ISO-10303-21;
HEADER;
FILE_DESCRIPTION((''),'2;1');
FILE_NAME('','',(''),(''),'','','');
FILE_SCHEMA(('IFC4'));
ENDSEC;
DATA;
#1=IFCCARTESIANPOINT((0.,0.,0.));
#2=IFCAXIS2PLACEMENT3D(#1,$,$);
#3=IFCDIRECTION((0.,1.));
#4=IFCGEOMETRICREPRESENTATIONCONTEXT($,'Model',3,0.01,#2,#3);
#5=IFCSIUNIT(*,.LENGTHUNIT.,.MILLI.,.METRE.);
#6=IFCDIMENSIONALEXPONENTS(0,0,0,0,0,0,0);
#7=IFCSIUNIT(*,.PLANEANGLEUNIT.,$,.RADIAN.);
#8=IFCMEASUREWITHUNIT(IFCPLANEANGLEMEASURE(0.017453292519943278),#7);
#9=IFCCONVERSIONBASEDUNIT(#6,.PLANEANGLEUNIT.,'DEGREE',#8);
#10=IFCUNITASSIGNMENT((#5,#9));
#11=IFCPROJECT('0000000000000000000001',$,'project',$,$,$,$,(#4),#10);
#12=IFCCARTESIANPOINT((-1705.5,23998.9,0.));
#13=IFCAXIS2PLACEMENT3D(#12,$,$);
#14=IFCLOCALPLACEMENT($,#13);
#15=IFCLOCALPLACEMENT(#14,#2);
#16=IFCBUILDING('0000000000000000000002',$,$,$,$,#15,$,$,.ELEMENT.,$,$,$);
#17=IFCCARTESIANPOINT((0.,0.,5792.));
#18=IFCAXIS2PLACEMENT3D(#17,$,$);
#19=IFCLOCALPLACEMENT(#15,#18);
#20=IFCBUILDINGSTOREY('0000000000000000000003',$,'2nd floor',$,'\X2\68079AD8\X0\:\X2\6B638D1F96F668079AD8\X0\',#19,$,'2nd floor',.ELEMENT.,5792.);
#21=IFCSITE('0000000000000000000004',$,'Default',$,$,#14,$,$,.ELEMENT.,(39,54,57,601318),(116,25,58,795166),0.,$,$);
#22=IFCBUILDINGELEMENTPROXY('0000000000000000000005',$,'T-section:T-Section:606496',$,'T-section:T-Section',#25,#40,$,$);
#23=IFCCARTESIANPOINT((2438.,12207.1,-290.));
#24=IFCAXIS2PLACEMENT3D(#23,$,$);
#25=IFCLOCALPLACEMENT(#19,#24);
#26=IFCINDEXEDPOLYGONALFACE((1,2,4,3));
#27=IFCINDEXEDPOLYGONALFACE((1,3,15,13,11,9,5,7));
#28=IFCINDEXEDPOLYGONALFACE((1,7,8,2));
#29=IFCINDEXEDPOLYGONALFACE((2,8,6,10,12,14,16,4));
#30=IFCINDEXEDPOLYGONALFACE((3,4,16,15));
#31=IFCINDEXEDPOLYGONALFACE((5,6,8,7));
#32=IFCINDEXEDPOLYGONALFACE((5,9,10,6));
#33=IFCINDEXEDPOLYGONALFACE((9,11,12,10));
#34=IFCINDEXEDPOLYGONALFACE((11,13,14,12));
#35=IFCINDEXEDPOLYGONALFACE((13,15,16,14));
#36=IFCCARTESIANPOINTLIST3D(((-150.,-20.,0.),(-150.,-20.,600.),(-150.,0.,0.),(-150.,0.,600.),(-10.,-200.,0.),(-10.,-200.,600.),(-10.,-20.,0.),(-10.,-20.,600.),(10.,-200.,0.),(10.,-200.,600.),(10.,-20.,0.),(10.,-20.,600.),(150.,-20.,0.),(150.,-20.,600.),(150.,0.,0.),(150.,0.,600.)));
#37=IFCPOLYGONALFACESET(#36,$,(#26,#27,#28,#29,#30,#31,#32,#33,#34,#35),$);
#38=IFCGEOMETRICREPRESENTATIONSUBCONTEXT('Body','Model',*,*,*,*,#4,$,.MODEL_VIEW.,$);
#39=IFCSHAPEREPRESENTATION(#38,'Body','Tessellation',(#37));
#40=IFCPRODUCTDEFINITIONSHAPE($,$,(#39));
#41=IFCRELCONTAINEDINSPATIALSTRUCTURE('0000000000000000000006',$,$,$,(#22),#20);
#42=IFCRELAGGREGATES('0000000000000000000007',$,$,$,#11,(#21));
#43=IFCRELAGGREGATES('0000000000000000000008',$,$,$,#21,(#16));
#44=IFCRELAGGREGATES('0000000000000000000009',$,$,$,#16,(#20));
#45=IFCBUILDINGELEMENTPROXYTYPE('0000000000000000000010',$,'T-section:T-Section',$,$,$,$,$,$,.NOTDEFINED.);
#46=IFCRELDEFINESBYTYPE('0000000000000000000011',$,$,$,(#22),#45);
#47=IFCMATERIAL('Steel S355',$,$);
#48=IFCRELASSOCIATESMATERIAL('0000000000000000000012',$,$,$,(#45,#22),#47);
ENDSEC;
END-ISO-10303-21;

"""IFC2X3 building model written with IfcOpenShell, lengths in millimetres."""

from ifc_helpers import new_model, entity, si_unit, converted_unit, direction, frame, origin, place, context, subcontext, project, spatial, polyline, outline, extrude, source, transform, mapped, material, type_object, type_shapes, element, save


model = new_model("IFC2X3")

# Units and contexts
model_context = context("Model", 3, precision=0.01, world=origin(), true_north=direction((0.0, 1.0)))
body_context = subcontext(model_context, "Body", "Model", "MODEL_VIEW")
ifc_project = project(units=[si_unit("LENGTHUNIT", "METRE", prefix="MILLI"), converted_unit("PLANEANGLEUNIT", "DEGREE", entity("IfcPlaneAngleMeasure", 0.017453292519943278), si_unit("PLANEANGLEUNIT", "RADIAN"), dimensions=[0, 0, 0, 0, 0, 0, 0])], contexts=[model_context])

# Site, building, storey
site_placement = place(None, frame((-1705.5, 23998.9, 0.0)))
site = spatial("IfcSite", under=ifc_project, at=site_placement, Name="Default", CompositionType="ELEMENT", RefLatitude=(39, 54, 57, 601318), RefLongitude=(116, 25, 58, 795166), RefElevation=0.0)
building_placement = place(site_placement, origin())
building = spatial("IfcBuilding", under=site, at=building_placement, CompositionType="ELEMENT")
storey_placement = place(building_placement, frame((0.0, 0.0, 5792.0)))
storey = spatial("IfcBuildingStorey", under=building, at=storey_placement, Name="2nd floor", ObjectType="标高:正负零标高", LongName="2nd floor", CompositionType="ELEMENT", Elevation=5792.0)

# Shared definitions
ifc_material_1 = material(Name="Steel S355")

# Building element proxy
building_element_proxy_type_1 = type_object("IfcBuildingElementProxyType", Name="T-section:T-Section", PredefinedType="NOTDEFINED", material=ifc_material_1)
shared_shape_1 = source(origin(), body_context, "Body", "SweptSolid", [
    extrude(outline(polyline([(-10.0, -140.0), (10.0, -140.0), (10.0, 40.0), (150.0, 40.0), (150.0, 60.0), (-150.0, 60.0), (-150.0, 40.0), (-10.0, 40.0), (-10.0, -140.0)])), frame((0.0, -60.0, 0.0)), (0.0, 0.0, 1.0), 600.0),
])
type_shapes(building_element_proxy_type_1, [shared_shape_1])
proxy_placement = place(storey_placement, frame((2438.0, 12207.1, -290.0)))
element("IfcBuildingElementProxy", 1, at=proxy_placement, inside=storey, type_object=building_element_proxy_type_1, material=ifc_material_1, Name="T-section:T-Section:606496", ObjectType="T-section:T-Section", context=body_context, shape_type="MappedRepresentation", body=[
    mapped(shared_shape_1, transform((0.0, 0.0, 0.0), scale=1.0)),
])

save(model, "model.ifc")
